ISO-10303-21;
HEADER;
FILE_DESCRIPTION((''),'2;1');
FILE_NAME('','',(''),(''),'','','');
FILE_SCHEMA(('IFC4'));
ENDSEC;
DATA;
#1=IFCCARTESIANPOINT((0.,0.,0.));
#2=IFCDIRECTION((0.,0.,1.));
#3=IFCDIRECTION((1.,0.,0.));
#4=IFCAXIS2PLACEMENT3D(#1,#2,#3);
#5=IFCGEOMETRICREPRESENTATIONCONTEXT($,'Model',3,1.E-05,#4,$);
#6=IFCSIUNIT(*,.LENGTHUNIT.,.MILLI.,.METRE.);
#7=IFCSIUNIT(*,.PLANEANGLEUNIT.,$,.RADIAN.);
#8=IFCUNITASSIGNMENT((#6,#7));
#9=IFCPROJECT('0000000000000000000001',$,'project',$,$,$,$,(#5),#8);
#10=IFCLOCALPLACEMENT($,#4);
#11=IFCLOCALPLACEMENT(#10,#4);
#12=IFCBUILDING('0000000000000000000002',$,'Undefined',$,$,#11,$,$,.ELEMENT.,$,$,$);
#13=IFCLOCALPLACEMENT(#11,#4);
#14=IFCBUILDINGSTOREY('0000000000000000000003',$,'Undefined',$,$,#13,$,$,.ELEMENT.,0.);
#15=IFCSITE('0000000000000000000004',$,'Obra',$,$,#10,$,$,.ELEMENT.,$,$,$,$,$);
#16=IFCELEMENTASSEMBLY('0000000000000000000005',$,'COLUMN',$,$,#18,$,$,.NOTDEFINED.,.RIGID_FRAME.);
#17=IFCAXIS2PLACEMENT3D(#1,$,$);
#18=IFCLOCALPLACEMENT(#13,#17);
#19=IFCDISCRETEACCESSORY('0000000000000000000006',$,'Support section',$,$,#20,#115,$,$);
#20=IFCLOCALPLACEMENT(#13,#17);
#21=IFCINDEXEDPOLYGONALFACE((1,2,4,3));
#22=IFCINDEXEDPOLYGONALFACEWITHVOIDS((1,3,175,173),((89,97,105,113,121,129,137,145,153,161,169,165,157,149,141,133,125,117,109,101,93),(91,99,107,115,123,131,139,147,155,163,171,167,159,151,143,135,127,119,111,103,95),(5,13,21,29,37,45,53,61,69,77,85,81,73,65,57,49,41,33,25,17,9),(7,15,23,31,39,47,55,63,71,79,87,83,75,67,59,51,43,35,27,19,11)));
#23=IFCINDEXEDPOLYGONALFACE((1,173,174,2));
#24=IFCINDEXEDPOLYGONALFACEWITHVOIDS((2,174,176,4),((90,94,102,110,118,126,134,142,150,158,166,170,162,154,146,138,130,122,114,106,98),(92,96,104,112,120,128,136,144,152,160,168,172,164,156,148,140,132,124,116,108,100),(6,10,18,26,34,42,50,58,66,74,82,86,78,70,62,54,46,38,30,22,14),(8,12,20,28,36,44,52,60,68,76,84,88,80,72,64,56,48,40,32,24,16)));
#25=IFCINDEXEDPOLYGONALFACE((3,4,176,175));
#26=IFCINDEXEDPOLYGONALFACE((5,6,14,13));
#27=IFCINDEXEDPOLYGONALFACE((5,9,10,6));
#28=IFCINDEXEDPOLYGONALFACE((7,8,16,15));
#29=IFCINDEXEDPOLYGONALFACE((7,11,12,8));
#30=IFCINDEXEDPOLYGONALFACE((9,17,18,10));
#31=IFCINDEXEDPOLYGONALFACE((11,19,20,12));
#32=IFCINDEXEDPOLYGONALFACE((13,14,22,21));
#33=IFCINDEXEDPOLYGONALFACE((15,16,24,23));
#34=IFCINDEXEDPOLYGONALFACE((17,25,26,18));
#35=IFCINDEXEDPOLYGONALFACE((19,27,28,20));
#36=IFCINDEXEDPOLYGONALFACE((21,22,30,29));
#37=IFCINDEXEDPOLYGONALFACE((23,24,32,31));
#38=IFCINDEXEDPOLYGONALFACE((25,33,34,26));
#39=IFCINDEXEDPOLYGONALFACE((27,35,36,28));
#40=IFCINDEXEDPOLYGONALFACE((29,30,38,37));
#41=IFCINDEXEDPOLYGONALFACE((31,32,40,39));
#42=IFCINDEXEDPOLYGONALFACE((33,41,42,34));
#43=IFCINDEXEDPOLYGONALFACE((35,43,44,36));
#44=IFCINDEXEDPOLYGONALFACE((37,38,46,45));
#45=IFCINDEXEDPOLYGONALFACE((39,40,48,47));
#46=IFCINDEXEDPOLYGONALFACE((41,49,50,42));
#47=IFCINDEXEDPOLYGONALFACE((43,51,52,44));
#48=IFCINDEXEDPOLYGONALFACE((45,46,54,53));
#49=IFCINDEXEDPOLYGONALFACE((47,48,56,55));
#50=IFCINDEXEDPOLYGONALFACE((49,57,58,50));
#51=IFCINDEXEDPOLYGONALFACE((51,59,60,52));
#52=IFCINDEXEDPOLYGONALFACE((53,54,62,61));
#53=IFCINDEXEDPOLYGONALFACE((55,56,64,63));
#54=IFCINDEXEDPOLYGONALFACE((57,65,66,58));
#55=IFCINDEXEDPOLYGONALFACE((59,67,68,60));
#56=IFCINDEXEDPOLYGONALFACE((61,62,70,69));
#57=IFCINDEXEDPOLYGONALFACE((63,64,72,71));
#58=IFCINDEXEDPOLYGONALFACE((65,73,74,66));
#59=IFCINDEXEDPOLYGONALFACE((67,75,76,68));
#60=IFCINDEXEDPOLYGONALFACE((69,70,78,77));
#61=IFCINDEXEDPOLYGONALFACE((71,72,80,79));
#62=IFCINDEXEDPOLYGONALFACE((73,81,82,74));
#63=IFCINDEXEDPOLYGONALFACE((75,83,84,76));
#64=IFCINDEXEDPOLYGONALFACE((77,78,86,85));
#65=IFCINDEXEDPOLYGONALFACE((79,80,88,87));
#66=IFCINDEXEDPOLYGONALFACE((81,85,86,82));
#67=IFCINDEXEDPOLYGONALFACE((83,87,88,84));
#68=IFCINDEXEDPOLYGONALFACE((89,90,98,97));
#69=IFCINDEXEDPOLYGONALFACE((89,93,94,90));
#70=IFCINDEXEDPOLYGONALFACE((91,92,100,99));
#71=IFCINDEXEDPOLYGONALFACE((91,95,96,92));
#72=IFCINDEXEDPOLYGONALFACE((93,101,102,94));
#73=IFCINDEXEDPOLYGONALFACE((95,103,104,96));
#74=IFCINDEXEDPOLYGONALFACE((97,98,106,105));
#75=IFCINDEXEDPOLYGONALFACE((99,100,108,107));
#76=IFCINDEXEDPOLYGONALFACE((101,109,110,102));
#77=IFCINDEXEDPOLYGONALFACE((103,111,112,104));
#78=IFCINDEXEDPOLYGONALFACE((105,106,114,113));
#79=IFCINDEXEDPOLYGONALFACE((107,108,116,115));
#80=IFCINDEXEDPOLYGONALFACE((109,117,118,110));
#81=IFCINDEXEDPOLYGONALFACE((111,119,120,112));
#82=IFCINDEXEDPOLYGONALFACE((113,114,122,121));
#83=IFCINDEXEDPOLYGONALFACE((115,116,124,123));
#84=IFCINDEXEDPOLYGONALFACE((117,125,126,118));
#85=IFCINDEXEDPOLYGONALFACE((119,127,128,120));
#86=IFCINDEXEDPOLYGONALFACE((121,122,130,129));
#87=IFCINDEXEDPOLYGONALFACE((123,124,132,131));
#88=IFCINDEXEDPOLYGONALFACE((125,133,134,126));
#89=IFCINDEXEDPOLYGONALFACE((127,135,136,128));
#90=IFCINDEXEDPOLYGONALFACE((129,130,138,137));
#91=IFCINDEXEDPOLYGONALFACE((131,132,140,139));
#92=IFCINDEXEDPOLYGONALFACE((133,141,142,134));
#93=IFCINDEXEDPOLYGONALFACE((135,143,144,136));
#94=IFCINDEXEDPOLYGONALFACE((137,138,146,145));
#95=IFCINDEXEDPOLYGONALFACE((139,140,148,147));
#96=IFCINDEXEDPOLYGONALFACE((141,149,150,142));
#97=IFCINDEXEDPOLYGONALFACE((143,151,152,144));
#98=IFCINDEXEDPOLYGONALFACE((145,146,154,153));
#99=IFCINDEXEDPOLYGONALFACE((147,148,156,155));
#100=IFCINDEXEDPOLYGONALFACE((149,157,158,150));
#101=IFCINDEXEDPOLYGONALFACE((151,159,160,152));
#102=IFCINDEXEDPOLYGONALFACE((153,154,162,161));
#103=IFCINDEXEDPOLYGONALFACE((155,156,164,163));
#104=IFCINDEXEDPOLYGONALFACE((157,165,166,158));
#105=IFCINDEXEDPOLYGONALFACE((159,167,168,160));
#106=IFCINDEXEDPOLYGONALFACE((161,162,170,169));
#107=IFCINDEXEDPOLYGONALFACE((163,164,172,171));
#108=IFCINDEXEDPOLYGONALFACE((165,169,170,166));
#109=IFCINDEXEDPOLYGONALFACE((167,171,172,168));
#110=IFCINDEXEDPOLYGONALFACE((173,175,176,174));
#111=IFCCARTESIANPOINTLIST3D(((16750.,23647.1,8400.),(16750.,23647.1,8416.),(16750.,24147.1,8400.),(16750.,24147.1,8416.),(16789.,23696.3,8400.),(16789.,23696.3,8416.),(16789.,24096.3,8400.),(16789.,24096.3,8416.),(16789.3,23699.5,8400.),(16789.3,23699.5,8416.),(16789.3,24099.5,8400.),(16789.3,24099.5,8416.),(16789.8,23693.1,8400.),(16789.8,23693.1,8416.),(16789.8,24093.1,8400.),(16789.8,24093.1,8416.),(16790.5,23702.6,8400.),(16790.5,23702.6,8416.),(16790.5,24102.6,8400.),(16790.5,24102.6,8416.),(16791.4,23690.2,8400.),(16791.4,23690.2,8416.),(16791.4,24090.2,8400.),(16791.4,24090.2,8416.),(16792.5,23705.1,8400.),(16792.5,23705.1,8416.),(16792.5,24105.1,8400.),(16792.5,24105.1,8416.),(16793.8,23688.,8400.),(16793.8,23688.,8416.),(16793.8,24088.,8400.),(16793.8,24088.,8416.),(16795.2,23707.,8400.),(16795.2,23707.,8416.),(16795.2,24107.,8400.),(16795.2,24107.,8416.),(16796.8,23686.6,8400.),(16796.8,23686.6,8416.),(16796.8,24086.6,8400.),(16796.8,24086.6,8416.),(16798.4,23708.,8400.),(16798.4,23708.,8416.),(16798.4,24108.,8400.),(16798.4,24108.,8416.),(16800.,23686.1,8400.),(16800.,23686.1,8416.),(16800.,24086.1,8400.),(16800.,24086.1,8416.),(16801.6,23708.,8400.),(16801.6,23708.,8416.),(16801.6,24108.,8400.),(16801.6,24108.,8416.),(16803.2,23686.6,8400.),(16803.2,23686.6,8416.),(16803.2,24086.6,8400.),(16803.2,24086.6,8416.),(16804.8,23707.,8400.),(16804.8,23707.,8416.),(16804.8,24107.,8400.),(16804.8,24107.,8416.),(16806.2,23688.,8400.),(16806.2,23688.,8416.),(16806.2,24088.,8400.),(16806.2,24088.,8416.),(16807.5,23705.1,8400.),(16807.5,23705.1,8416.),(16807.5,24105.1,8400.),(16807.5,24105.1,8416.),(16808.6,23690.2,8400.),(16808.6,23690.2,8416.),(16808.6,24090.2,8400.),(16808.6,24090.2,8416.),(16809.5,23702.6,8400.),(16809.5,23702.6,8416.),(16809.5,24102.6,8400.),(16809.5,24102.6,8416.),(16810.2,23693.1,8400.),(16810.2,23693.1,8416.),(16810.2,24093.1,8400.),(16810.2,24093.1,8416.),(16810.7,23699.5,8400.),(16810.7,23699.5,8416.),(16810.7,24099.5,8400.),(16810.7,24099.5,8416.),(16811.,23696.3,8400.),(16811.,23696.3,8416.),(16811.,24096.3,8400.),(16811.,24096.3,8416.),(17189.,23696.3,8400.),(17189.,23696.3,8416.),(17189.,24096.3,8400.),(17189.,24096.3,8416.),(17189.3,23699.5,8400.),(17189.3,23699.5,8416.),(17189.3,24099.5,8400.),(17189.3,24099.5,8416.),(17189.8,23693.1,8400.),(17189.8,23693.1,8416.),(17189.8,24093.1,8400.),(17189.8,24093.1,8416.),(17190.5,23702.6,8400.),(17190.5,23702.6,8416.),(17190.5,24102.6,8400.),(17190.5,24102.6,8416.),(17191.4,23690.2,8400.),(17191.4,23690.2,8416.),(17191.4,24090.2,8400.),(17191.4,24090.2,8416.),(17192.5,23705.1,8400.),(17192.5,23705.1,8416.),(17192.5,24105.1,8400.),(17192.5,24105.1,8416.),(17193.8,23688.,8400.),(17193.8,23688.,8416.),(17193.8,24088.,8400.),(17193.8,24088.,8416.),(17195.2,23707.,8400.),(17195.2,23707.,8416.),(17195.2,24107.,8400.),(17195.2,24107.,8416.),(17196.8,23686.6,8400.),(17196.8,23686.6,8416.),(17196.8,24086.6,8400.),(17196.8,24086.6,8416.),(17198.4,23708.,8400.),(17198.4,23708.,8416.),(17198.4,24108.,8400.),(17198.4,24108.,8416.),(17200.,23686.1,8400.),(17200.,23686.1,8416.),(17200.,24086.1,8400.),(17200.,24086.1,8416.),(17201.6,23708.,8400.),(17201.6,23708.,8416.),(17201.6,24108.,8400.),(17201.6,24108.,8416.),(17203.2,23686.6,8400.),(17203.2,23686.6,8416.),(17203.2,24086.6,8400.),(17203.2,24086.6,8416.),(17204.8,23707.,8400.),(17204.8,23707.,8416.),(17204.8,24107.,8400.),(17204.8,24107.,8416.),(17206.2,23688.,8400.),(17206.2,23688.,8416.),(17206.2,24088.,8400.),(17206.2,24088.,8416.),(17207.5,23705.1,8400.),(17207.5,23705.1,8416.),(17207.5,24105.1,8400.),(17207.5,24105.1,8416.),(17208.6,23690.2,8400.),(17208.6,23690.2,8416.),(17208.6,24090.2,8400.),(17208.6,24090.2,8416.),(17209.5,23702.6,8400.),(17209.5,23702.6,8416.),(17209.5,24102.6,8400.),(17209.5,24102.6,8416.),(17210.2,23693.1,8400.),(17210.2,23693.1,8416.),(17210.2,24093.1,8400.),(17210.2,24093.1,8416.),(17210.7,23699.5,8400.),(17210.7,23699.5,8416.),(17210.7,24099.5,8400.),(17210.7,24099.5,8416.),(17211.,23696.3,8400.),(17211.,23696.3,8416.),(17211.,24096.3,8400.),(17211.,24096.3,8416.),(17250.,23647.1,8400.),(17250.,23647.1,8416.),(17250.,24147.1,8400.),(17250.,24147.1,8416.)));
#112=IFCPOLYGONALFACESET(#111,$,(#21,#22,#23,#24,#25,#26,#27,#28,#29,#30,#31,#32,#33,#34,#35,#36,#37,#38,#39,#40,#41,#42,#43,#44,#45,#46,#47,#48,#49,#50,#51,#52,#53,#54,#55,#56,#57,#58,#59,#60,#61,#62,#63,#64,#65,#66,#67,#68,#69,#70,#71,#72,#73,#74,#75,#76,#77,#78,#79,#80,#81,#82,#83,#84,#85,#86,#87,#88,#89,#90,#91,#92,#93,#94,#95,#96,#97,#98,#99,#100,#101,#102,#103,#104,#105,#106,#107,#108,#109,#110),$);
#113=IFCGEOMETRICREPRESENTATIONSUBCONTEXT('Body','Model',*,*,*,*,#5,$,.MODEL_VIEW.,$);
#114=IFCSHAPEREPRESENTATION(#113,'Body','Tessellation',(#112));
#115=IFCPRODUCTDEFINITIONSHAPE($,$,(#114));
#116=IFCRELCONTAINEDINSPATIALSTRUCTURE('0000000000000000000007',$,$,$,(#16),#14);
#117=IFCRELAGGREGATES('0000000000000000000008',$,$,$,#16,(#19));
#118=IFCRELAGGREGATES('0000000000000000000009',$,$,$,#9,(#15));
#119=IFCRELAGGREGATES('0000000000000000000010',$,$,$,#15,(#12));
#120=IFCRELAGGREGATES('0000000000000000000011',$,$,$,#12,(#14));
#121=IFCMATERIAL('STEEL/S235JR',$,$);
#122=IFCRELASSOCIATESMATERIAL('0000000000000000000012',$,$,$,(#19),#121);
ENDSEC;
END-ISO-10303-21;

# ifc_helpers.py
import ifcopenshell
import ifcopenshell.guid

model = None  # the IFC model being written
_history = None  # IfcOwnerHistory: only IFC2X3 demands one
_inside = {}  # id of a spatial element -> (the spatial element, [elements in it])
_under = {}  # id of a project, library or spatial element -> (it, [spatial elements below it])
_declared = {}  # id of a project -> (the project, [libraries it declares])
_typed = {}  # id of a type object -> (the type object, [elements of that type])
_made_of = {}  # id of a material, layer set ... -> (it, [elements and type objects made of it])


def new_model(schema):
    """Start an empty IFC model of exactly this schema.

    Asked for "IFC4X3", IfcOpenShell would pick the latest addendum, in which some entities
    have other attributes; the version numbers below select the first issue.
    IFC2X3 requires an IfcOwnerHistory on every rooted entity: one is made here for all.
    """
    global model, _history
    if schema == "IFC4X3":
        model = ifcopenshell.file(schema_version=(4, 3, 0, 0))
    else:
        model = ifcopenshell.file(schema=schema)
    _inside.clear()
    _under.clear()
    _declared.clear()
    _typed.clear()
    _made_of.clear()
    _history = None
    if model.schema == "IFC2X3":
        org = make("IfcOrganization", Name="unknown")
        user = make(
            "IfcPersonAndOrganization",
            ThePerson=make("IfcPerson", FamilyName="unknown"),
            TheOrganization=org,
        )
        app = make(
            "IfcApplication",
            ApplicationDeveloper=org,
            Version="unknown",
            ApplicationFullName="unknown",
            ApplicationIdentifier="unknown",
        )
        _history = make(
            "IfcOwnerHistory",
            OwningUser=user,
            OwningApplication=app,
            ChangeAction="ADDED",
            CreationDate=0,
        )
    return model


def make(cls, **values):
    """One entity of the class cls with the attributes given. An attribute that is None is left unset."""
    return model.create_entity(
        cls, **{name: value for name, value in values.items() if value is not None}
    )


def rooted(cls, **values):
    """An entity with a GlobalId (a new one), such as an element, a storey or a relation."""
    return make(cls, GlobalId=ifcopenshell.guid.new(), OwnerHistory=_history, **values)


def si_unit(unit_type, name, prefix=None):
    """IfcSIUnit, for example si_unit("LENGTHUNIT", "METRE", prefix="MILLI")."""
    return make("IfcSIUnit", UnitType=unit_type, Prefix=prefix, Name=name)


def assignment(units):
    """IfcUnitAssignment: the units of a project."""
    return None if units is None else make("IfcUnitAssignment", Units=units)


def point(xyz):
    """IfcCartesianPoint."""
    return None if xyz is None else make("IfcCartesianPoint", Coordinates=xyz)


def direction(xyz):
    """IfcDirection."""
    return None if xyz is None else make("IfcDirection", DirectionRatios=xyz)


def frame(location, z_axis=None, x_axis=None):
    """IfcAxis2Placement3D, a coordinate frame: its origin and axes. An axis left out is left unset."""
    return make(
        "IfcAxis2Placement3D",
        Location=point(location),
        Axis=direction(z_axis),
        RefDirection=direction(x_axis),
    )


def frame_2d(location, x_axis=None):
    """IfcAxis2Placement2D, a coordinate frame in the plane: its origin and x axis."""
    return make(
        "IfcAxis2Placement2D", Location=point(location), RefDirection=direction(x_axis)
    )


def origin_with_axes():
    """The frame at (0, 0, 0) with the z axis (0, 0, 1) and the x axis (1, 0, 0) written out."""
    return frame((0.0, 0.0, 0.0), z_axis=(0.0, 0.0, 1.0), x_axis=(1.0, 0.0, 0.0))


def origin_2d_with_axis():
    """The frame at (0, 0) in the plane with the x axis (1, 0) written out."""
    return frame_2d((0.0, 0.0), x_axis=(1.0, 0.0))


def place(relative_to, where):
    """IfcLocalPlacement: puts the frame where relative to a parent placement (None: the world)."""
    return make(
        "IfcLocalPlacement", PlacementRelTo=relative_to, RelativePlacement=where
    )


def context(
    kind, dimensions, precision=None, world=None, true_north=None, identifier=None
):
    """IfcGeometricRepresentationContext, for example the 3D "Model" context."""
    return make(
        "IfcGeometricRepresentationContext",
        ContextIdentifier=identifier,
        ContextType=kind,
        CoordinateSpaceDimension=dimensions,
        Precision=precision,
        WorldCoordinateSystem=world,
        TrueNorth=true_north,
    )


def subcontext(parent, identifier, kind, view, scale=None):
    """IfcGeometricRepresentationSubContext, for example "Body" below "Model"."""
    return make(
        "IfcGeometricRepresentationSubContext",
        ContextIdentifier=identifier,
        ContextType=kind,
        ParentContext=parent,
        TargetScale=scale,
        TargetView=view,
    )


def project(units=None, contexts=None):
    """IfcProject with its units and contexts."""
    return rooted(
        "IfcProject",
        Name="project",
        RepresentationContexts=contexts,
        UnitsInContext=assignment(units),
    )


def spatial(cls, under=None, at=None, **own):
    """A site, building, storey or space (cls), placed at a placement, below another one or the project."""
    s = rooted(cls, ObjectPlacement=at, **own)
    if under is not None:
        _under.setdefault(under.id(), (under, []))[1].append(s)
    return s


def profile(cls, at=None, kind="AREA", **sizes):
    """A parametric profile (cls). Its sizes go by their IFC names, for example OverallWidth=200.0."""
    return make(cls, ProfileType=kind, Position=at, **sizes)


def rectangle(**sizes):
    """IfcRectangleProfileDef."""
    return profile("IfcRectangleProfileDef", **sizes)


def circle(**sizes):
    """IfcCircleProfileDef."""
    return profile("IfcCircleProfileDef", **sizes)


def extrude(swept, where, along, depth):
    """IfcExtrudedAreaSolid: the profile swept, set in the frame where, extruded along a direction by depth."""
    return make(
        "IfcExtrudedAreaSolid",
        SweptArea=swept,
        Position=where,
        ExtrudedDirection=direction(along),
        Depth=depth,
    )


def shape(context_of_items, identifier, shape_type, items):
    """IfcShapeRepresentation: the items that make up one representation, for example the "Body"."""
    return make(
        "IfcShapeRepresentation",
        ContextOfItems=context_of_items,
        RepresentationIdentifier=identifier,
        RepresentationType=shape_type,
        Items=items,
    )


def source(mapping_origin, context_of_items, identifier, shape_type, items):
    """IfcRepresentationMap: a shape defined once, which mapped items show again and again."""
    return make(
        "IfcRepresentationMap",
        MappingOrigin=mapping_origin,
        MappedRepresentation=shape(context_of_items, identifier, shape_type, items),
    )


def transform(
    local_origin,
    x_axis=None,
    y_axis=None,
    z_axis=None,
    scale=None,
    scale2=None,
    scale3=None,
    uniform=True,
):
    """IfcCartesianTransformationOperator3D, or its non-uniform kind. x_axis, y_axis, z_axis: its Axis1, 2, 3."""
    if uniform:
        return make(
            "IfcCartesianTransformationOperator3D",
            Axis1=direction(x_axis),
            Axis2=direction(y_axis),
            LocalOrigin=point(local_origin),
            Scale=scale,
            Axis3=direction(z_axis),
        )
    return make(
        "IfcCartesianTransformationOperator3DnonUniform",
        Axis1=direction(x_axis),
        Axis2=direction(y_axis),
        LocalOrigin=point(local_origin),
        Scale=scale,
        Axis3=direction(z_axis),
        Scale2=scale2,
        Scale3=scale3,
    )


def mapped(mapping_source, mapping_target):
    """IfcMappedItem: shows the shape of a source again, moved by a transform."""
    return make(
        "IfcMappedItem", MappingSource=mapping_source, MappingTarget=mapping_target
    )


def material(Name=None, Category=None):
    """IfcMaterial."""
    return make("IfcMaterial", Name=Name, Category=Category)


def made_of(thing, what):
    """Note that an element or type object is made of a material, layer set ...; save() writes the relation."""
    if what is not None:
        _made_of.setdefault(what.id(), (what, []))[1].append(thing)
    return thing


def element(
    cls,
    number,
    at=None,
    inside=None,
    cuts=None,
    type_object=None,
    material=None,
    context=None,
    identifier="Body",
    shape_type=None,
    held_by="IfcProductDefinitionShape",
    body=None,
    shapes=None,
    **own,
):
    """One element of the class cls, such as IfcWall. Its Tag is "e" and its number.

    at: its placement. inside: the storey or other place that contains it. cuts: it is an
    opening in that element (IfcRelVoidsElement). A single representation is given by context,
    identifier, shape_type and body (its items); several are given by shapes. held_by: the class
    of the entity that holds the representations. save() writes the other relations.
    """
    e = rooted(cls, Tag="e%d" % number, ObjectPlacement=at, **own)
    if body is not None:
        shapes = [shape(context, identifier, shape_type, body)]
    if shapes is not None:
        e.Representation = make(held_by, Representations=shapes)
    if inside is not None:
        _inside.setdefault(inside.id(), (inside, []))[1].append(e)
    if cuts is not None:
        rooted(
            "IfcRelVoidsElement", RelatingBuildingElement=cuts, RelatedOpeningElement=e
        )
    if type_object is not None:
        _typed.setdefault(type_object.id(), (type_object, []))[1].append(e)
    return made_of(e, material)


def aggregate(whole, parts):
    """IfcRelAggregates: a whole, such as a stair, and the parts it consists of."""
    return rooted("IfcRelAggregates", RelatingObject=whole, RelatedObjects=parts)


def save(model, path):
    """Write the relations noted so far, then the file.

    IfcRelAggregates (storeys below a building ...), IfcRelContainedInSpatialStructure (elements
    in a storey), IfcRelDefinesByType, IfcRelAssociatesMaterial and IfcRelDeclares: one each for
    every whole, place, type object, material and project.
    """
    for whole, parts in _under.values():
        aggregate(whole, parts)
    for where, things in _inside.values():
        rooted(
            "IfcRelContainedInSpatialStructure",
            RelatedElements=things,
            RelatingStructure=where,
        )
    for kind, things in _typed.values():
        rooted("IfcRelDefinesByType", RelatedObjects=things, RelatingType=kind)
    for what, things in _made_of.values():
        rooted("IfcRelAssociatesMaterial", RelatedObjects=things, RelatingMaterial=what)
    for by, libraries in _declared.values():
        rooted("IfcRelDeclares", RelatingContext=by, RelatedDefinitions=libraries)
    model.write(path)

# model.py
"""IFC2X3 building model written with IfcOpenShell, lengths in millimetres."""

from ifc_helpers import new_model, si_unit, frame, origin_with_axes, origin_2d_with_axis, place, context, subcontext, project, spatial, rectangle, circle, extrude, source, transform, mapped, material, element, aggregate, save


model = new_model("IFC2X3")

# Units and contexts
model_context = context("Model", 3, precision=1e-05, world=origin_with_axes())
body_context = subcontext(model_context, "Body", "Model", "MODEL_VIEW")
ifc_project = project(units=[si_unit("LENGTHUNIT", "METRE", prefix="MILLI"), si_unit("PLANEANGLEUNIT", "RADIAN")], contexts=[model_context])

# Site, building, storey
site_placement = place(None, origin_with_axes())
site = spatial("IfcSite", under=ifc_project, at=site_placement, Name="Obra", CompositionType="ELEMENT")
building_placement = place(site_placement, origin_with_axes())
building = spatial("IfcBuilding", under=site, at=building_placement, Name="Undefined", CompositionType="ELEMENT")
storey_placement = place(building_placement, origin_with_axes())
storey = spatial("IfcBuildingStorey", under=building, at=storey_placement, Name="Undefined", CompositionType="ELEMENT", Elevation=0.0)

# Element assembly
ifc_material_1 = material(Name="STEEL/S235JR")
assembly_1_placement = place(storey_placement, origin_with_axes())
assembly_1 = element("IfcElementAssembly", 1, at=assembly_1_placement, inside=storey, Name="COLUMN", AssemblyPlace="NOTDEFINED", PredefinedType="RIGID_FRAME")

# Discrete accessory, opening
shared_shape_1 = source(origin_with_axes(), body_context, "Body", "SweptSolid", [
    extrude(circle(Radius=11.0, at=origin_2d_with_axis()), frame((0.0, -0.1, 0.0), z_axis=(0.0, 1.0, 0.0), x_axis=(1.0, 0.0, 0.0)), (0.0, 0.0, 1.0), 16.2),
])
discrete_accessory_1_placement = place(assembly_1_placement, frame((17000.0, 23647.1, 8408.0), z_axis=(-1.0, 0.0, 0.0), x_axis=(0.0, 1.0, 0.0)))
discrete_accessory_1 = element("IfcDiscreteAccessory", 2, at=discrete_accessory_1_placement, material=ifc_material_1, Name="Support section", context=body_context, shape_type="SweptSolid", body=[
    extrude(rectangle(XDim=16.0, YDim=500.0, at=origin_2d_with_axis()), frame((500.0, 0.0, 0.0), z_axis=(-1.0, 0.0, 0.0), x_axis=(0.0, -1.0, 0.0)), (0.0, 0.0, 1.0), 500.0),
])
opening_1_placement = place(assembly_1_placement, frame((17000.0, 24100.1, 8416.0), z_axis=(1.0, 0.0, 0.0), x_axis=(0.0, -1.0, 0.0)))
element("IfcOpeningElement", 3, at=opening_1_placement, cuts=discrete_accessory_1, ObjectType="Opening", context=body_context, shape_type="MappedRepresentation", body=[
    mapped(shared_shape_1, transform((3.0, 0.0, 200.0))),
    mapped(shared_shape_1, transform((3.0, 0.0, -200.0))),
    mapped(shared_shape_1, transform((403.0, 0.0, 200.0))),
    mapped(shared_shape_1, transform((403.0, 0.0, -200.0))),
])
aggregate(assembly_1, [discrete_accessory_1])

save(model, "model.ifc")
